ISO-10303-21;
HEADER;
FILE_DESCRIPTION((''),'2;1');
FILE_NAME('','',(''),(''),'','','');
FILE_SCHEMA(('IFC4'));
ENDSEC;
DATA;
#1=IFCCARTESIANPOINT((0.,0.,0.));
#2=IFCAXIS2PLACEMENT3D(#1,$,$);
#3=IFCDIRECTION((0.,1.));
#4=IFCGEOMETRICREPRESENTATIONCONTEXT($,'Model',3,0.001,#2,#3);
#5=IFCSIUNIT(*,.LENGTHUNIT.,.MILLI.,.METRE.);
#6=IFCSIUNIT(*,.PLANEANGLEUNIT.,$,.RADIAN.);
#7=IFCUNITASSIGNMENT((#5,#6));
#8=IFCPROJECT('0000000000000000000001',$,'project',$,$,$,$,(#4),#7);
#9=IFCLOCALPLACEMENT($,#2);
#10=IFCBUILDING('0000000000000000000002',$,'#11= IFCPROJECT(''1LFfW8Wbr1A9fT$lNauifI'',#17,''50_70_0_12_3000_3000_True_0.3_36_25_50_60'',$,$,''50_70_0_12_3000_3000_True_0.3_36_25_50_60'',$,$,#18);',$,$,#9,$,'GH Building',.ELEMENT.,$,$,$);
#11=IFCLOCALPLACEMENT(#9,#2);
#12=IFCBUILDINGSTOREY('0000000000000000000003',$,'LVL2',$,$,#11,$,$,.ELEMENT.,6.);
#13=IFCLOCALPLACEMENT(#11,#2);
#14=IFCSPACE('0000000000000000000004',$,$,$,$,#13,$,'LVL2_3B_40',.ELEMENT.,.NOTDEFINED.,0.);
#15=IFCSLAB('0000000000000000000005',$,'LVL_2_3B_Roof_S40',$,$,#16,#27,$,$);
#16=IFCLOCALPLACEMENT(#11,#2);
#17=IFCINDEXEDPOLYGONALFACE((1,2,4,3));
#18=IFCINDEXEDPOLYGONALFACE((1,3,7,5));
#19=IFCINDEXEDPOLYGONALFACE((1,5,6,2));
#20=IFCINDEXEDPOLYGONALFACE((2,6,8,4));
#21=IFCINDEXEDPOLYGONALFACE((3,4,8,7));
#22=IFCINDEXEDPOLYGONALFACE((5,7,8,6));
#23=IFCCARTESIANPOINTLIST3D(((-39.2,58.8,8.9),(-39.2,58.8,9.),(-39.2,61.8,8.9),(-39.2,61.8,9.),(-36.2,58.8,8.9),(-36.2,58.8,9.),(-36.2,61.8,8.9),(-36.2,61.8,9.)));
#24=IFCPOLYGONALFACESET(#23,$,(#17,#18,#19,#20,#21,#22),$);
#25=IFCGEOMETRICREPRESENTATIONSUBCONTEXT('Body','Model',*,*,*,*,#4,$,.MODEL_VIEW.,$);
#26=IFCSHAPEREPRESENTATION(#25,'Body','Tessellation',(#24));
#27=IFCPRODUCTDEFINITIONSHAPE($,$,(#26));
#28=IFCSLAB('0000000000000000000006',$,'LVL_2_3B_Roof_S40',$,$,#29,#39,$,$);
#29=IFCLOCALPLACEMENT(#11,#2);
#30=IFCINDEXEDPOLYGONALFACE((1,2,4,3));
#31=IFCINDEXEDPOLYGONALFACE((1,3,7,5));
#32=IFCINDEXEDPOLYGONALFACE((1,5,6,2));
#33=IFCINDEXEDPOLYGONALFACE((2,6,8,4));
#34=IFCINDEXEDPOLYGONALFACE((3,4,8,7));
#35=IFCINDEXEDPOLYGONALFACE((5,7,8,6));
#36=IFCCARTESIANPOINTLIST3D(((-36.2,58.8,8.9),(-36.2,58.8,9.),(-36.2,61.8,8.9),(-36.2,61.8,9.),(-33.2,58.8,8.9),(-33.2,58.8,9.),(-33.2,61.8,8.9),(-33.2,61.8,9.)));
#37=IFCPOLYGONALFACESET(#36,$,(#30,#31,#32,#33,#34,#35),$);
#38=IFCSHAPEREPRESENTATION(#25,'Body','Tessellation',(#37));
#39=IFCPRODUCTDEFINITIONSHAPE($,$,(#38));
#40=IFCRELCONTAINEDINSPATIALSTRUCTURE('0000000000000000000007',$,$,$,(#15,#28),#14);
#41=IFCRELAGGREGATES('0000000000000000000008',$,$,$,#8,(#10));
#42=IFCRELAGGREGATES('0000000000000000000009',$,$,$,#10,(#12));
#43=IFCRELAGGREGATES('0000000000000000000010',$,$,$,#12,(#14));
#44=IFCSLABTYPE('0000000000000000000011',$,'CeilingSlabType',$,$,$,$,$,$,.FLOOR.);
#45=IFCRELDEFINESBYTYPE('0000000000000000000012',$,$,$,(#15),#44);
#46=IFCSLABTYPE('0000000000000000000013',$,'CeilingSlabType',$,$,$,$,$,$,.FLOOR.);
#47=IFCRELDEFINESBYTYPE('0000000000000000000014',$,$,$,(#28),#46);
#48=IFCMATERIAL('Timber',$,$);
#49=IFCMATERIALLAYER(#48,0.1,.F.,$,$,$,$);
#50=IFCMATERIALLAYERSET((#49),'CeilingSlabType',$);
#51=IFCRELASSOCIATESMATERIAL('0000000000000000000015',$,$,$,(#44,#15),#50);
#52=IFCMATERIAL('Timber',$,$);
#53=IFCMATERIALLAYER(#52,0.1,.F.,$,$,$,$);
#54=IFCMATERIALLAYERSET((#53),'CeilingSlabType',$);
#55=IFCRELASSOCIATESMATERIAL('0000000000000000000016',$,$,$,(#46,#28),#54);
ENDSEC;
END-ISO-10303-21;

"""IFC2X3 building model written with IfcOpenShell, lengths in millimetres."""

from ifc_helpers import new_model, si_unit, direction, frame, frame_2d, origin, place, context, subcontext, project, spatial, rectangle, extrude, material, layer, layer_set, layer_usage, type_object, element, save


model = new_model("IFC2X3")

# Units and contexts
model_context = context("Model", 3, precision=0.001, world=origin(), true_north=direction((0.0, 1.0)))
body_context = subcontext(model_context, "Body", "Model", "MODEL_VIEW")
ifc_project = project(units=[si_unit("LENGTHUNIT", "METRE", prefix="MILLI"), si_unit("PLANEANGLEUNIT", "RADIAN")], contexts=[model_context])

# Building, storey
building_placement = place(None, origin())
building = spatial("IfcBuilding", under=ifc_project, at=building_placement, Name="#11= IFCPROJECT('1LFfW8Wbr1A9fT$lNauifI',#17,'50_70_0_12_3000_3000_True_0.3_36_25_50_60',$,$,'50_70_0_12_3000_3000_True_0.3_36_25_50_60',$,$,#18);", LongName="GH Building", CompositionType="ELEMENT")
storey_placement = place(building_placement, origin())
storey = spatial("IfcBuildingStorey", under=building, at=storey_placement, Name="LVL2", CompositionType="ELEMENT", Elevation=6.0)

# Shared definitions
space_1_placement = place(storey_placement, origin())
space_1 = spatial("IfcSpace", under=storey, at=space_1_placement, LongName="LVL2_3B_40", CompositionType="ELEMENT", InteriorOrExteriorSpace="NOTDEFINED", ElevationWithFlooring=0.0)

# Slabs
ifc_material_1 = material(Name="Timber")
ifc_layer_1 = layer(ifc_material_1, 0.1, ventilated=False)
ifc_layer_set_1 = layer_set([ifc_layer_1], Name="CeilingSlabType")
ifc_layer_usage_1 = layer_usage(ifc_layer_set_1, "AXIS3", "NEGATIVE", -0.1)
slab_type_1 = type_object("IfcSlabType", Name="CeilingSlabType", PredefinedType="FLOOR", material=ifc_layer_set_1)
slab_1_placement = place(space_1_placement, frame((-39.2, 58.8, 8.9)))
element("IfcSlab", 1, at=slab_1_placement, inside=space_1, type_object=slab_type_1, material=ifc_layer_usage_1, Name="LVL_2_3B_Roof_S40", context=body_context, shape_type="SweptSolid", body=[
    extrude(rectangle(XDim=3.0, YDim=3.0, at=frame_2d((1.5, 1.5))), origin(), (0.0, 0.0, 1.0), 0.1),
])
ifc_material_2 = material(Name="Timber")
ifc_layer_2 = layer(ifc_material_2, 0.1, ventilated=False)
ifc_layer_set_2 = layer_set([ifc_layer_2], Name="CeilingSlabType")
ifc_layer_usage_2 = layer_usage(ifc_layer_set_2, "AXIS3", "NEGATIVE", -0.1)
slab_type_2 = type_object("IfcSlabType", Name="CeilingSlabType", PredefinedType="FLOOR", material=ifc_layer_set_2)
slab_2_placement = place(space_1_placement, frame((-36.2, 58.8, 8.9)))
element("IfcSlab", 2, at=slab_2_placement, inside=space_1, type_object=slab_type_2, material=ifc_layer_usage_2, Name="LVL_2_3B_Roof_S40", context=body_context, shape_type="SweptSolid", body=[
    extrude(rectangle(XDim=3.0, YDim=3.0, at=frame_2d((1.5, 1.5))), origin(), (0.0, 0.0, 1.0), 0.1),
])

save(model, "model.ifc")
